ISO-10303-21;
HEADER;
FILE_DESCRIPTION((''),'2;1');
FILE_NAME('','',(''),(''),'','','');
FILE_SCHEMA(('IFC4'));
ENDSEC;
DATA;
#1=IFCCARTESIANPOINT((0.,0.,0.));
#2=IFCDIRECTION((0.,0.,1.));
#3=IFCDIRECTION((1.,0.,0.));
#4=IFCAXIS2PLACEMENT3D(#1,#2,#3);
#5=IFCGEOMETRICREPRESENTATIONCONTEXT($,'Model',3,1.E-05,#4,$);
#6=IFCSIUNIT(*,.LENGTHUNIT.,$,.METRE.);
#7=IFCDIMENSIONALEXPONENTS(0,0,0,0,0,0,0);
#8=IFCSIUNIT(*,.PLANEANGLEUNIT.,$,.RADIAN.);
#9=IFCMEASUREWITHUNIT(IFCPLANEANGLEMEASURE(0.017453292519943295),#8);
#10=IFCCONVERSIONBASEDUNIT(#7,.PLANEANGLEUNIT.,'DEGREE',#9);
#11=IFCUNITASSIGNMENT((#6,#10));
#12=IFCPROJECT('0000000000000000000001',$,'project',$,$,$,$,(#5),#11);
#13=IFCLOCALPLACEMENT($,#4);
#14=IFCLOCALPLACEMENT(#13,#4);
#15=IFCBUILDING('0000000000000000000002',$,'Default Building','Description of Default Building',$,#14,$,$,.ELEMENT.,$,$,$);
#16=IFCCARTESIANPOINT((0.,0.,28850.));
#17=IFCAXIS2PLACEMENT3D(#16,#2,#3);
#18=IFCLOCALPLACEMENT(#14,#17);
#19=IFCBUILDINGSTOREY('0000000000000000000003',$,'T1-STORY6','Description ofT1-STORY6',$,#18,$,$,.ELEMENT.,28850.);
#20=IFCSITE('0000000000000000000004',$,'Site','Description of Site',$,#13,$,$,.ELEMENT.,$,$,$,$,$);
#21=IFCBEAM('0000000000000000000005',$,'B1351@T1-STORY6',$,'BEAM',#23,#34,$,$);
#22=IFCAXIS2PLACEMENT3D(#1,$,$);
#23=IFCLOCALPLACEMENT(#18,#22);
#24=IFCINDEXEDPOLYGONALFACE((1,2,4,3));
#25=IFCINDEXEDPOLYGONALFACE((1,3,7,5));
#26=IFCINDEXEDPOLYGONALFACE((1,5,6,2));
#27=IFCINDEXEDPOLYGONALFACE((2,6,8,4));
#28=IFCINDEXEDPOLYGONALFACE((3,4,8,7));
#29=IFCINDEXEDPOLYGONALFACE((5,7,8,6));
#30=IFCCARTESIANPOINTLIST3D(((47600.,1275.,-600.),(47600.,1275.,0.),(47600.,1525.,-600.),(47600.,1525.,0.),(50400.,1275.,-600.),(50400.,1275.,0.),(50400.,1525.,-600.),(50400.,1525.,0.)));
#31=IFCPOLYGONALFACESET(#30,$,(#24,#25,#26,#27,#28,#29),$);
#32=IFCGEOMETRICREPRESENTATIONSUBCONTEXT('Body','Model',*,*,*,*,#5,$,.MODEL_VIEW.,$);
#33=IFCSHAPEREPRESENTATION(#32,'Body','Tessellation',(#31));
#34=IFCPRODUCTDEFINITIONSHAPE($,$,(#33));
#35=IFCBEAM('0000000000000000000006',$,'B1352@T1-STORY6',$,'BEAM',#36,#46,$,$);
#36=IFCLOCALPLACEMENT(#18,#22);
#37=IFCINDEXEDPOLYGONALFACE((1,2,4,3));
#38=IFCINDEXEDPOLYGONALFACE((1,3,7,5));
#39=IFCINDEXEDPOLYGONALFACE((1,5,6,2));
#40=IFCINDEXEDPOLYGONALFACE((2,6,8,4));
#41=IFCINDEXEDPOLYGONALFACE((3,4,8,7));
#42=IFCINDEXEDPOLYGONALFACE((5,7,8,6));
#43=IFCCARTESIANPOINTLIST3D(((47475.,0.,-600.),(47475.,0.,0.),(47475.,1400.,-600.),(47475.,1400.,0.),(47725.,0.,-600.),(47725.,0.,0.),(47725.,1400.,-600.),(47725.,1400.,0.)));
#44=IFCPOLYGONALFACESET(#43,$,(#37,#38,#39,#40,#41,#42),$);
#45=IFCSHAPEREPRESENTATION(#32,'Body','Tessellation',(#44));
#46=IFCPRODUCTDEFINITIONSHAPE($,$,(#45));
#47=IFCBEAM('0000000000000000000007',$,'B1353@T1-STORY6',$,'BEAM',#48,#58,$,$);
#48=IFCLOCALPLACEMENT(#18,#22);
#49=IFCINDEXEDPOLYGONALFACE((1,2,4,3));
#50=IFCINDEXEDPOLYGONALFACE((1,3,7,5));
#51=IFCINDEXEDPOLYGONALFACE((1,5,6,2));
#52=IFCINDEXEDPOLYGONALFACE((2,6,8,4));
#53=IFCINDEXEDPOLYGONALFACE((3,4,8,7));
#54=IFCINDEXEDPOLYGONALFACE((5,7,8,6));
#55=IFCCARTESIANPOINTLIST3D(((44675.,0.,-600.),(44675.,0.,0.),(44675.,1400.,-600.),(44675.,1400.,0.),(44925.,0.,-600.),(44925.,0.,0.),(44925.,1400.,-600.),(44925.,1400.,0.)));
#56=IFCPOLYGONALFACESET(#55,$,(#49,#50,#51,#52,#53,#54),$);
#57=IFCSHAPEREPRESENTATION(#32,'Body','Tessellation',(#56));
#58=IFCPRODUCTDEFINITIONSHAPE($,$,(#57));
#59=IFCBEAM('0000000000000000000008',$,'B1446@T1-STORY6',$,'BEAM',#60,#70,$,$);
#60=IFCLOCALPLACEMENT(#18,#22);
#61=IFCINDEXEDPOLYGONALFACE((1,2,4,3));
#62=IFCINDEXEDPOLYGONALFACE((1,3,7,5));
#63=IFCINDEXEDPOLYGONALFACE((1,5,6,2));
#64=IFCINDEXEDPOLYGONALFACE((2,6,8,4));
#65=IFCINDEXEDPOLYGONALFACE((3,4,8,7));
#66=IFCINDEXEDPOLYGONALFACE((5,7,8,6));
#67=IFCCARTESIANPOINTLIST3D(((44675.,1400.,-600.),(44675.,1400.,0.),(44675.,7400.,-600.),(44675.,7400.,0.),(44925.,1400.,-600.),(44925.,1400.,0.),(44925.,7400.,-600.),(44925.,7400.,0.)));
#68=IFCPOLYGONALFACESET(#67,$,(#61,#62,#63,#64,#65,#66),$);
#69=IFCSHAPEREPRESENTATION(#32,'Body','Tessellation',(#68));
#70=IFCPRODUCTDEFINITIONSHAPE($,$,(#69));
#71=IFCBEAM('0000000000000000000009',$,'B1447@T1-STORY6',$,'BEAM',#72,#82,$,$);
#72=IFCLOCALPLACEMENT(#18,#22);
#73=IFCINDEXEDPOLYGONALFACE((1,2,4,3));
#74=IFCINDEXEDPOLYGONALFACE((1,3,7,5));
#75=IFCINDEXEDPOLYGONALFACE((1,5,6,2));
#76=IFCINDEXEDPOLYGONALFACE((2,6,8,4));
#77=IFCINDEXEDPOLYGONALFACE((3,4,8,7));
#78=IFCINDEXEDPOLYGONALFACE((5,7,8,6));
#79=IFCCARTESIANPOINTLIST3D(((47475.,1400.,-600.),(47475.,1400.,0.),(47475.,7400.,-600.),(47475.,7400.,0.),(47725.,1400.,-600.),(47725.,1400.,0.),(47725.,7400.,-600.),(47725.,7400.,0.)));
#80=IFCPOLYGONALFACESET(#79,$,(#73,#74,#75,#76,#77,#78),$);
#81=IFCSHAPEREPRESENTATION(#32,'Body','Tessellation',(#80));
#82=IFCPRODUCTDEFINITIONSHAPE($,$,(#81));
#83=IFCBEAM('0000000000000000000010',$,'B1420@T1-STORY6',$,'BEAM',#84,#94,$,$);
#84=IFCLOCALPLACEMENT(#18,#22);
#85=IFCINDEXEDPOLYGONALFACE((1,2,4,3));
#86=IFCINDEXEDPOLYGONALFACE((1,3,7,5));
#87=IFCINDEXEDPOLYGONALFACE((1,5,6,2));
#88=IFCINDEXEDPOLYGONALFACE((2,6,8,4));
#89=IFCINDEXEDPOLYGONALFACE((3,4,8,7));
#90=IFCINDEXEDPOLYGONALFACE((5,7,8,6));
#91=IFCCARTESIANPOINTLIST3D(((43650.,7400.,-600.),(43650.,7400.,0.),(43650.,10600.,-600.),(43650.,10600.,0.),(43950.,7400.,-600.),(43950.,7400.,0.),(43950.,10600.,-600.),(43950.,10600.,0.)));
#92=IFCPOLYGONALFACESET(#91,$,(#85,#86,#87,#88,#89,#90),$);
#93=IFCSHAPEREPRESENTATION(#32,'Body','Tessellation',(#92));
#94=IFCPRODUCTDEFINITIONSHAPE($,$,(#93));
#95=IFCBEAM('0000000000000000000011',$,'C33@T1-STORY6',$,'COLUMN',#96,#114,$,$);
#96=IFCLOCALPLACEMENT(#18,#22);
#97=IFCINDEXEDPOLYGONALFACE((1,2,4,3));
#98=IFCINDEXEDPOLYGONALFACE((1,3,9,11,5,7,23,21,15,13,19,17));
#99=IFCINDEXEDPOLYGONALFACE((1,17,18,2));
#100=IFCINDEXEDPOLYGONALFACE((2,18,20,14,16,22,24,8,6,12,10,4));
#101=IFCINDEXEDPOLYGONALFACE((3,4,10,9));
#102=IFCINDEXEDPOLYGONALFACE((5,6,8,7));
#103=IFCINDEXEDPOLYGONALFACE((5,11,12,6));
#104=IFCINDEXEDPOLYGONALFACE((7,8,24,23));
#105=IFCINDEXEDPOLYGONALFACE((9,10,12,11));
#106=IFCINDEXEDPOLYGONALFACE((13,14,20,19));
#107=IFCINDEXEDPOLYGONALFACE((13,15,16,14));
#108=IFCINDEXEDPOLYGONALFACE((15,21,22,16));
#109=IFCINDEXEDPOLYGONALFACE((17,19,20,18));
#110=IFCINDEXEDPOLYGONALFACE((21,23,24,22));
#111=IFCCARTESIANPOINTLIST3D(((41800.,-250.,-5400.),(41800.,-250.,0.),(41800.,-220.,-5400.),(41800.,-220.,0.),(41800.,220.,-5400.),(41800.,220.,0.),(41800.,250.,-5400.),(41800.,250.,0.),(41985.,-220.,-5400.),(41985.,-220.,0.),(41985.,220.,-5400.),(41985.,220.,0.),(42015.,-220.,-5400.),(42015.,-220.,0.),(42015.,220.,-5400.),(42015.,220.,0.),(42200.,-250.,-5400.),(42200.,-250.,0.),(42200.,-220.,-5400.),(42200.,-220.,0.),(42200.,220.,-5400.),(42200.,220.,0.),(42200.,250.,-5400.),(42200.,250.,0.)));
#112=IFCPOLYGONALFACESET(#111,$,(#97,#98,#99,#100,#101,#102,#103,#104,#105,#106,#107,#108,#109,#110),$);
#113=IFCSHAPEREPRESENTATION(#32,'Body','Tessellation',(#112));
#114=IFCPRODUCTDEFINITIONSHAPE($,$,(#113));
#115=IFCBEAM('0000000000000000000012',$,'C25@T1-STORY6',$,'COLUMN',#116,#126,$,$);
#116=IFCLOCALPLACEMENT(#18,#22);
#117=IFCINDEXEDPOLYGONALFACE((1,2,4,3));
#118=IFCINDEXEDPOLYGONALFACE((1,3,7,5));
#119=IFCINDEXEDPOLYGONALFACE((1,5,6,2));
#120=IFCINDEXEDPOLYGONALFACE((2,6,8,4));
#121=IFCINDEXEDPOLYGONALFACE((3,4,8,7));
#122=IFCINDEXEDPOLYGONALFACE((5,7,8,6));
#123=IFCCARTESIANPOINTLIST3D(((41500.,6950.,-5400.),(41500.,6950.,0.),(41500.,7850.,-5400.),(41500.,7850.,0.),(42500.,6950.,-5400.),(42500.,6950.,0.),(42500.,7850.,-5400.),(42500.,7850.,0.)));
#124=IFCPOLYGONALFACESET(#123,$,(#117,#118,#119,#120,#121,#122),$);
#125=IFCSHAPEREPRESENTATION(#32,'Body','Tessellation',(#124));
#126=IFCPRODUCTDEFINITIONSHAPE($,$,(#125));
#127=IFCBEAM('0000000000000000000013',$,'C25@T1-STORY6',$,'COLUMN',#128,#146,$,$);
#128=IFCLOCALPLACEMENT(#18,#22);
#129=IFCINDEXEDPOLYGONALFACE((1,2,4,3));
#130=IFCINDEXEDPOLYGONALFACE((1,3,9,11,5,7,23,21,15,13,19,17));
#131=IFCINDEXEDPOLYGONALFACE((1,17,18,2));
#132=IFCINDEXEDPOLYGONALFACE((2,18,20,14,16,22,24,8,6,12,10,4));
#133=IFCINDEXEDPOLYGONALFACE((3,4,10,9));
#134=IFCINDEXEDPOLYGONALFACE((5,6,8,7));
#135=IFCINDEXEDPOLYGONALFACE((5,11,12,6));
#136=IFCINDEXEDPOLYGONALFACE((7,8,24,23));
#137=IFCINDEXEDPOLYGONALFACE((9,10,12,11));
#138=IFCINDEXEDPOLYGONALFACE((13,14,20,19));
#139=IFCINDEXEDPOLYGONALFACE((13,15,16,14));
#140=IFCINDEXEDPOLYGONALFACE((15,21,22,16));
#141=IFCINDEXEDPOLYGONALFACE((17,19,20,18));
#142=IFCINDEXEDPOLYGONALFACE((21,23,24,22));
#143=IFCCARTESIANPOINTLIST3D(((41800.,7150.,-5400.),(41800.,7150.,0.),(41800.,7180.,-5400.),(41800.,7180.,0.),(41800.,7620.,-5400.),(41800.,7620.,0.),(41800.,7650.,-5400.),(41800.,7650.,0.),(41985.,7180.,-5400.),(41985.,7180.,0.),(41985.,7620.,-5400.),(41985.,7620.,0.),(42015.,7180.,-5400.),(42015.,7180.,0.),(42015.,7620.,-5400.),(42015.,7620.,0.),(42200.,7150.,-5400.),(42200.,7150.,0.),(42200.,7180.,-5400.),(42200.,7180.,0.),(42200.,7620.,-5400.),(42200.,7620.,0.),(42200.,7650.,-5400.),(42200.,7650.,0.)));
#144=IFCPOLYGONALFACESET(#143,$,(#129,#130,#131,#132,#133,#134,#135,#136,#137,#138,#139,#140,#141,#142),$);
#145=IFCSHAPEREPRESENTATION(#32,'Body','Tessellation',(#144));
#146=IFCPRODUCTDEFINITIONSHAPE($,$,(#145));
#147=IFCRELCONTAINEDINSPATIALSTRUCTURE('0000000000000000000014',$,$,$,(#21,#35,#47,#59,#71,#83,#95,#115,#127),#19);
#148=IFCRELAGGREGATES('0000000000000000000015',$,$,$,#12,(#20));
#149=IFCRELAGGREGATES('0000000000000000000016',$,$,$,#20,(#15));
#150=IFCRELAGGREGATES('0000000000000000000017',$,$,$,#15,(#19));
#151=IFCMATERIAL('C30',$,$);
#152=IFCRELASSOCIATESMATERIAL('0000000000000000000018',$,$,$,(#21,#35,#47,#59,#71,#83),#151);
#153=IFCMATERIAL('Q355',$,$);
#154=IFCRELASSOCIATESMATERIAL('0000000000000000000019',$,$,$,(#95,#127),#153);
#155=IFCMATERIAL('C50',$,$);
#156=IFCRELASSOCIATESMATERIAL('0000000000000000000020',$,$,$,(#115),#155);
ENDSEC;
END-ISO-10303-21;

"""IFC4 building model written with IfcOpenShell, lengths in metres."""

from ifc_helpers import new_model, entity, si_unit, converted_unit, frame, origin_with_axes, place, context, subcontext, project, spatial, rectangle, i_section, extrude, material, element, save


model = new_model("IFC4")

# Units and contexts
model_context = context("Model", 3, precision=1e-05, world=origin_with_axes())
body_context = subcontext(model_context, "Body", "Model", "MODEL_VIEW")
ifc_project = project(units=[si_unit("LENGTHUNIT", "METRE"), converted_unit("PLANEANGLEUNIT", "DEGREE", entity("IfcPlaneAngleMeasure", 0.017453292519943295), si_unit("PLANEANGLEUNIT", "RADIAN"), dimensions=[0, 0, 0, 0, 0, 0, 0])], contexts=[model_context])

# Site, building, storey
site_placement = place(None, origin_with_axes())
site = spatial("IfcSite", under=ifc_project, at=site_placement, Name="Site", Description="Description of Site", CompositionType="ELEMENT")
building_placement = place(site_placement, origin_with_axes())
building = spatial("IfcBuilding", under=site, at=building_placement, Name="Default Building", Description="Description of Default Building", CompositionType="ELEMENT")
storey_placement = place(building_placement, frame((0.0, 0.0, 28850.0), z_axis=(0.0, 0.0, 1.0), x_axis=(1.0, 0.0, 0.0)))
storey = spatial("IfcBuildingStorey", under=building, at=storey_placement, Name="T1-STORY6", Description="Description ofT1-STORY6", CompositionType="ELEMENT", Elevation=28850.0)

# Beams
ifc_material_1 = material(Name="C30")
ifc_material_2 = material(Name="C50")
for number, where, z_axis, x_axis, name in (
    (1, (47600.0, 1400.0, -300.0), (1.0, 0.0, 0.0), (0.0, 1.0, 0.0), "B1351@T1-STORY6"),
):
    element("IfcBeam", number, at=place(storey_placement, frame(where, z_axis=z_axis, x_axis=x_axis)), inside=storey, material=ifc_material_1, Name=name, ObjectType="BEAM", context=body_context, shape_type="SweptSolid", body=[
        extrude(rectangle(XDim=250.0, YDim=600.0), origin_with_axes(), (0.0, 0.0, 1.0), 2800.0),
    ])
for number, where, z_axis, x_axis, name in (
    (2, (47600.0, 0.0, -300.0), (0.0, 1.0, 0.0), (-1.0, 0.0, 0.0), "B1352@T1-STORY6"),
    (3, (44800.0, 0.0, -300.0), (0.0, 1.0, 0.0), (-1.0, 0.0, 0.0), "B1353@T1-STORY6"),
):
    element("IfcBeam", number, at=place(storey_placement, frame(where, z_axis=z_axis, x_axis=x_axis)), inside=storey, material=ifc_material_1, Name=name, ObjectType="BEAM", context=body_context, shape_type="SweptSolid", body=[
        extrude(rectangle(XDim=250.0, YDim=600.0), origin_with_axes(), (0.0, 0.0, 1.0), 1400.0),
    ])
for number, where, z_axis, x_axis, name in (
    (4, (44800.0, 1400.0, -300.0), (0.0, 1.0, 0.0), (-1.0, 0.0, 0.0), "B1446@T1-STORY6"),
    (5, (47600.0, 1400.0, -300.0), (0.0, 1.0, 0.0), (-1.0, 0.0, 0.0), "B1447@T1-STORY6"),
):
    element("IfcBeam", number, at=place(storey_placement, frame(where, z_axis=z_axis, x_axis=x_axis)), inside=storey, material=ifc_material_1, Name=name, ObjectType="BEAM", context=body_context, shape_type="SweptSolid", body=[
        extrude(rectangle(XDim=250.0, YDim=600.0), origin_with_axes(), (0.0, 0.0, 1.0), 6000.0),
    ])
beam_1_placement = place(storey_placement, frame((43800.0, 7400.0, -300.0), z_axis=(0.0, 1.0, 0.0), x_axis=(-1.0, 0.0, 0.0)))
element("IfcBeam", 6, at=beam_1_placement, inside=storey, material=ifc_material_1, Name="B1420@T1-STORY6", ObjectType="BEAM", context=body_context, shape_type="SweptSolid", body=[
    extrude(rectangle(XDim=300.0, YDim=600.0), origin_with_axes(), (0.0, 0.0, 1.0), 3200.0),
])
ifc_material_3 = material(Name="Q355")
beam_2_placement = place(storey_placement, frame((42000.0, 0.0, -5400.0), z_axis=(0.0, 0.0, 1.0), x_axis=(-1.0, 0.0, 0.0)))
element("IfcBeam", 7, at=beam_2_placement, inside=storey, material=ifc_material_3, Name="C33@T1-STORY6", ObjectType="COLUMN", context=body_context, shape_type="SweptSolid", body=[
    extrude(i_section(OverallWidth=400.0, OverallDepth=500.0, WebThickness=30.0, FlangeThickness=30.0, FilletRadius=0.0), origin_with_axes(), (0.0, 0.0, 1.0), 5400.0),
])
beam_3_placement = place(storey_placement, frame((42000.0, 7400.0, -5400.0), z_axis=(0.0, 0.0, 1.0), x_axis=(-1.0, 0.0, 0.0)))
element("IfcBeam", 8, at=beam_3_placement, inside=storey, material=ifc_material_2, Name="C25@T1-STORY6", ObjectType="COLUMN", context=body_context, shape_type="SweptSolid", body=[
    extrude(rectangle(XDim=1000.0, YDim=900.0), origin_with_axes(), (0.0, 0.0, 1.0), 5400.0),
])
beam_4_placement = place(storey_placement, frame((42000.0, 7400.0, -5400.0), z_axis=(0.0, 0.0, 1.0), x_axis=(-1.0, 0.0, 0.0)))
element("IfcBeam", 9, at=beam_4_placement, inside=storey, material=ifc_material_3, Name="C25@T1-STORY6", ObjectType="COLUMN", context=body_context, shape_type="SweptSolid", body=[
    extrude(i_section(OverallWidth=400.0, OverallDepth=500.0, WebThickness=30.0, FlangeThickness=30.0, FilletRadius=0.0), origin_with_axes(), (0.0, 0.0, 1.0), 5400.0),
])

save(model, "model.ifc")
